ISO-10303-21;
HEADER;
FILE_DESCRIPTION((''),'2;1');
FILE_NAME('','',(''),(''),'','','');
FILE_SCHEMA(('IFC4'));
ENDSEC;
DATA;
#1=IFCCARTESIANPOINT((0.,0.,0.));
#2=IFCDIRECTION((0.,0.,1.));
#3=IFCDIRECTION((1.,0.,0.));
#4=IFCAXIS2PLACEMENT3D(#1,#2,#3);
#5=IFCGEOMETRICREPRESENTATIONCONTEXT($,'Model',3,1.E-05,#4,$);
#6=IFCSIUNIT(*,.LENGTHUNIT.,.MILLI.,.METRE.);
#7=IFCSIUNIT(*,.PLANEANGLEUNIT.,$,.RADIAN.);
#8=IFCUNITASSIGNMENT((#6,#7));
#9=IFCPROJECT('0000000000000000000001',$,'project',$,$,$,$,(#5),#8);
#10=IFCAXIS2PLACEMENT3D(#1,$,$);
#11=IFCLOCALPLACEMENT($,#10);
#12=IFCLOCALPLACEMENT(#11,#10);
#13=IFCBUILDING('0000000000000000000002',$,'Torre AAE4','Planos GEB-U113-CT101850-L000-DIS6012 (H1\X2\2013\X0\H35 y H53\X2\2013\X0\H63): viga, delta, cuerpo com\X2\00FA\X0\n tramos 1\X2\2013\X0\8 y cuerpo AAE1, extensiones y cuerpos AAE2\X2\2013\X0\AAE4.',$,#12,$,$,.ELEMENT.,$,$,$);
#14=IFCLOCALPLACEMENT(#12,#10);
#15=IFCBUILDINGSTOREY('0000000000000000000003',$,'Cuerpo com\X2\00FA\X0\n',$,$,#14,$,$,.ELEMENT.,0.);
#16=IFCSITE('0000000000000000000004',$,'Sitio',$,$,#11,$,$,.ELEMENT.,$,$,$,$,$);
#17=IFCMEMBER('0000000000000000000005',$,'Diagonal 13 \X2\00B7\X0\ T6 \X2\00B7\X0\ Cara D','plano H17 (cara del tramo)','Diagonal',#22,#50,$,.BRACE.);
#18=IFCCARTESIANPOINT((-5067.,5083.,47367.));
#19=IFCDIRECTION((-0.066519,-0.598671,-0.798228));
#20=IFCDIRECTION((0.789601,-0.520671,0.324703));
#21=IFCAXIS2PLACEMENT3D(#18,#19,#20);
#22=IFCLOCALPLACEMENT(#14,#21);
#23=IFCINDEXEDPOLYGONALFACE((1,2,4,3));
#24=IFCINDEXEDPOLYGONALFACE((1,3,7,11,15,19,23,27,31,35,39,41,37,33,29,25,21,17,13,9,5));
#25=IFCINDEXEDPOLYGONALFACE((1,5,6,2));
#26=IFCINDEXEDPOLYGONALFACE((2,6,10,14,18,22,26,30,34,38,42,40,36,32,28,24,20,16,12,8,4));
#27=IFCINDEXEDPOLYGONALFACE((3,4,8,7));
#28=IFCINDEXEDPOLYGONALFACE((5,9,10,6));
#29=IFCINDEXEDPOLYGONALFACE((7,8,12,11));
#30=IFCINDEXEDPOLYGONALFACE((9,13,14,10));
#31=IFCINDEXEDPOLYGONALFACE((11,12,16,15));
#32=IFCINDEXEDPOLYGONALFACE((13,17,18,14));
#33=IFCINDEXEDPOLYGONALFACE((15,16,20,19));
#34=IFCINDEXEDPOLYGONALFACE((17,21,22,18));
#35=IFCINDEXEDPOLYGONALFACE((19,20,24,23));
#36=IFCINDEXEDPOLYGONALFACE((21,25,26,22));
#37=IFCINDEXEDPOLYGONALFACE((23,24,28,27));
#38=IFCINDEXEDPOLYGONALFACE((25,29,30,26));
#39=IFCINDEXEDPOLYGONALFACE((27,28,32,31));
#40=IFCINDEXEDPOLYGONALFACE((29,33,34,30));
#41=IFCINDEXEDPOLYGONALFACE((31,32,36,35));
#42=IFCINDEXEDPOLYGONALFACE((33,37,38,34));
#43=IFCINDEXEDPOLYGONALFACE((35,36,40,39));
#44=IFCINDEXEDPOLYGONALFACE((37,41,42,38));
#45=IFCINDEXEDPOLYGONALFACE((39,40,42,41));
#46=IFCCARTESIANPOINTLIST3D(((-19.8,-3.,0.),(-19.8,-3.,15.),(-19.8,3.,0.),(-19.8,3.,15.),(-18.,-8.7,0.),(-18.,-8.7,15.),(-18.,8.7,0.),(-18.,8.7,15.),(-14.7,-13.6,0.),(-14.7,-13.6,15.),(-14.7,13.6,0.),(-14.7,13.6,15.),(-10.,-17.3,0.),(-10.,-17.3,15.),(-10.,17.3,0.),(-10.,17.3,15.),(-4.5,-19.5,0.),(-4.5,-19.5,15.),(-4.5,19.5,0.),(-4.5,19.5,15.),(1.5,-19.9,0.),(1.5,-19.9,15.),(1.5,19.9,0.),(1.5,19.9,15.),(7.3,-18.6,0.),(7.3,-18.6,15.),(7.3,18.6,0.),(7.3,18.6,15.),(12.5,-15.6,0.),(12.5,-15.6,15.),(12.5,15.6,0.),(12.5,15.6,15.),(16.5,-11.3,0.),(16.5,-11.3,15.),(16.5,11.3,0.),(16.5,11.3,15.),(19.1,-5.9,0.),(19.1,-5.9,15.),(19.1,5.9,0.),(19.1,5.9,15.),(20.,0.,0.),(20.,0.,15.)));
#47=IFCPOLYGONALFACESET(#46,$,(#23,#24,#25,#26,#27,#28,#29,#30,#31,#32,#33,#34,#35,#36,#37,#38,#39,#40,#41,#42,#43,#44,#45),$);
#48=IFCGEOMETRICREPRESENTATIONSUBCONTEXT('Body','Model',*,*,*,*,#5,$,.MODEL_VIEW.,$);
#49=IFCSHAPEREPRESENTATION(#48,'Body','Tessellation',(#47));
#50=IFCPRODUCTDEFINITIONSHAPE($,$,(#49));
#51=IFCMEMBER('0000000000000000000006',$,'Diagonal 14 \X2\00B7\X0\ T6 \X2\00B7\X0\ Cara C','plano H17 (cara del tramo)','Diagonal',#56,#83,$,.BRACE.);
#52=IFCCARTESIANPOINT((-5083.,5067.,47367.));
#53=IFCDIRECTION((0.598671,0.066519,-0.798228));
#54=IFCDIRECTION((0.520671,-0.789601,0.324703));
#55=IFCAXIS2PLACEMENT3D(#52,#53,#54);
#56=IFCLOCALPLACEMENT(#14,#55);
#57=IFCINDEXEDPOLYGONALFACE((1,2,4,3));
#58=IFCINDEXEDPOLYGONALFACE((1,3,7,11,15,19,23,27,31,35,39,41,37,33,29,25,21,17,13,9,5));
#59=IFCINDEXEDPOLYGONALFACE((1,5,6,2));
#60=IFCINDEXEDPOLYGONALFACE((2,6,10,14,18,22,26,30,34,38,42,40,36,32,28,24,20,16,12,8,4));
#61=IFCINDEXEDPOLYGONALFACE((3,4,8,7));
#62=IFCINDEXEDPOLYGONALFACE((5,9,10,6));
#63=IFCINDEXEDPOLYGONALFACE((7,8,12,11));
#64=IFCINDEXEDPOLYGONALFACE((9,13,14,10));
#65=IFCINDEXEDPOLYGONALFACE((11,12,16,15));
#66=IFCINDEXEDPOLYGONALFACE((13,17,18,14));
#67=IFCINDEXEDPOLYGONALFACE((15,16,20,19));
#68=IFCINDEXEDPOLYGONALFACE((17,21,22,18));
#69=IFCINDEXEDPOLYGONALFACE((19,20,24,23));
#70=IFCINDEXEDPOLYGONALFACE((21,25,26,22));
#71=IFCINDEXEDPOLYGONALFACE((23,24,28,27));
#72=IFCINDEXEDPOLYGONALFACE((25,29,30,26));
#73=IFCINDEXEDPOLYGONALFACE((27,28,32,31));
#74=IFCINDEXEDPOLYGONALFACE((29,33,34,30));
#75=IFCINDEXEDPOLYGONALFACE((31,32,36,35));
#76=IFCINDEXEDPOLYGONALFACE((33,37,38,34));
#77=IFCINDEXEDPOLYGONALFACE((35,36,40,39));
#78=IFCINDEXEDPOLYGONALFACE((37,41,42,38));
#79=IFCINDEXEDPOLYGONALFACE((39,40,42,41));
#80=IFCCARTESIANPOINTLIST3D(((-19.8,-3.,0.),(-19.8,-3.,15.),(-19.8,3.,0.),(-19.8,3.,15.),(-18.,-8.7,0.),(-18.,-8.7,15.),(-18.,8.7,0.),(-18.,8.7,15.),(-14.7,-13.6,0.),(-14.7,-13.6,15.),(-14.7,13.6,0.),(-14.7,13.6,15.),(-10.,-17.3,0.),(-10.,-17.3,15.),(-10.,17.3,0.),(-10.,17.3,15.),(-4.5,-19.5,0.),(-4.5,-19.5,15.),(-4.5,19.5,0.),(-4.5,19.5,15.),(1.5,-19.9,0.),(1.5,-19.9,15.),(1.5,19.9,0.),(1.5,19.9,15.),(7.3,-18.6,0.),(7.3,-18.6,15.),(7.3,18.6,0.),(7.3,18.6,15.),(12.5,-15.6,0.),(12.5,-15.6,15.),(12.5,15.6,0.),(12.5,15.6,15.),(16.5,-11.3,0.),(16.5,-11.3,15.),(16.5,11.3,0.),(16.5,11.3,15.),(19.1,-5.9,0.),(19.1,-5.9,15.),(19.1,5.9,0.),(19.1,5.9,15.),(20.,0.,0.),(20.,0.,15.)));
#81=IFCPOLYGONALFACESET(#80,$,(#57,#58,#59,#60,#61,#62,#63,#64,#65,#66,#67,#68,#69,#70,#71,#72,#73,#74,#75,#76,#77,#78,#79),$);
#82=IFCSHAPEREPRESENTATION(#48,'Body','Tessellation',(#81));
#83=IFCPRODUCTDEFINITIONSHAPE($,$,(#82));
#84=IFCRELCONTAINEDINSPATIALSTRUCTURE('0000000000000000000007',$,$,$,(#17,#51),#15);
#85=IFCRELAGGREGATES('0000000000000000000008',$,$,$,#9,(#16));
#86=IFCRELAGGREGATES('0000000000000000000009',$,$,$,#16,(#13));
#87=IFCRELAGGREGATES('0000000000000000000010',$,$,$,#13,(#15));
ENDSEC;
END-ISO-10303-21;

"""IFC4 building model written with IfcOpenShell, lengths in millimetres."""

from ifc_helpers import new_model, si_unit, frame, origin, origin_with_axes, place, context, subcontext, project, spatial, circle, extrude, element, save


model = new_model("IFC4")

# Units and contexts
model_context = context("Model", 3, precision=1e-05, world=origin_with_axes())
body_context = subcontext(model_context, "Body", "Model", "MODEL_VIEW")
ifc_project = project(units=[si_unit("LENGTHUNIT", "METRE", prefix="MILLI"), si_unit("PLANEANGLEUNIT", "RADIAN")], contexts=[model_context])

# Site, building, storey
site_placement = place(None, origin())
site = spatial("IfcSite", under=ifc_project, at=site_placement, Name="Sitio", CompositionType="ELEMENT")
building_placement = place(site_placement, origin())
building = spatial("IfcBuilding", under=site, at=building_placement, Name="Torre AAE4", Description="Planos GEB-U113-CT101850-L000-DIS6012 (H1–H35 y H53–H63): viga, delta, cuerpo común tramos 1–8 y cuerpo AAE1, extensiones y cuerpos AAE2–AAE4.", CompositionType="ELEMENT")
storey_placement = place(building_placement, origin())
storey = spatial("IfcBuildingStorey", under=building, at=storey_placement, Name="Cuerpo común", CompositionType="ELEMENT", Elevation=0.0)

# Members
for number, where, z_axis, x_axis, name in (
    (1, (-5067.0, 5083.0, 47367.0), (-0.066519, -0.598671, -0.798228), (0.789601, -0.520671, 0.324703), "Diagonal 13 · T6 · Cara D"),
    (2, (-5083.0, 5067.0, 47367.0), (0.598671, 0.066519, -0.798228), (0.520671, -0.789601, 0.324703), "Diagonal 14 · T6 · Cara C"),
):
    element("IfcMember", number, at=place(storey_placement, frame(where, z_axis=z_axis, x_axis=x_axis)), inside=storey, Name=name, Description="plano H17 (cara del tramo)", ObjectType="Diagonal", PredefinedType="BRACE", context=body_context, shape_type="SweptSolid", body=[
        extrude(circle(Radius=20.0), None, (0.0, 0.0, 1.0), 15.0),
    ])

save(model, "model.ifc")
